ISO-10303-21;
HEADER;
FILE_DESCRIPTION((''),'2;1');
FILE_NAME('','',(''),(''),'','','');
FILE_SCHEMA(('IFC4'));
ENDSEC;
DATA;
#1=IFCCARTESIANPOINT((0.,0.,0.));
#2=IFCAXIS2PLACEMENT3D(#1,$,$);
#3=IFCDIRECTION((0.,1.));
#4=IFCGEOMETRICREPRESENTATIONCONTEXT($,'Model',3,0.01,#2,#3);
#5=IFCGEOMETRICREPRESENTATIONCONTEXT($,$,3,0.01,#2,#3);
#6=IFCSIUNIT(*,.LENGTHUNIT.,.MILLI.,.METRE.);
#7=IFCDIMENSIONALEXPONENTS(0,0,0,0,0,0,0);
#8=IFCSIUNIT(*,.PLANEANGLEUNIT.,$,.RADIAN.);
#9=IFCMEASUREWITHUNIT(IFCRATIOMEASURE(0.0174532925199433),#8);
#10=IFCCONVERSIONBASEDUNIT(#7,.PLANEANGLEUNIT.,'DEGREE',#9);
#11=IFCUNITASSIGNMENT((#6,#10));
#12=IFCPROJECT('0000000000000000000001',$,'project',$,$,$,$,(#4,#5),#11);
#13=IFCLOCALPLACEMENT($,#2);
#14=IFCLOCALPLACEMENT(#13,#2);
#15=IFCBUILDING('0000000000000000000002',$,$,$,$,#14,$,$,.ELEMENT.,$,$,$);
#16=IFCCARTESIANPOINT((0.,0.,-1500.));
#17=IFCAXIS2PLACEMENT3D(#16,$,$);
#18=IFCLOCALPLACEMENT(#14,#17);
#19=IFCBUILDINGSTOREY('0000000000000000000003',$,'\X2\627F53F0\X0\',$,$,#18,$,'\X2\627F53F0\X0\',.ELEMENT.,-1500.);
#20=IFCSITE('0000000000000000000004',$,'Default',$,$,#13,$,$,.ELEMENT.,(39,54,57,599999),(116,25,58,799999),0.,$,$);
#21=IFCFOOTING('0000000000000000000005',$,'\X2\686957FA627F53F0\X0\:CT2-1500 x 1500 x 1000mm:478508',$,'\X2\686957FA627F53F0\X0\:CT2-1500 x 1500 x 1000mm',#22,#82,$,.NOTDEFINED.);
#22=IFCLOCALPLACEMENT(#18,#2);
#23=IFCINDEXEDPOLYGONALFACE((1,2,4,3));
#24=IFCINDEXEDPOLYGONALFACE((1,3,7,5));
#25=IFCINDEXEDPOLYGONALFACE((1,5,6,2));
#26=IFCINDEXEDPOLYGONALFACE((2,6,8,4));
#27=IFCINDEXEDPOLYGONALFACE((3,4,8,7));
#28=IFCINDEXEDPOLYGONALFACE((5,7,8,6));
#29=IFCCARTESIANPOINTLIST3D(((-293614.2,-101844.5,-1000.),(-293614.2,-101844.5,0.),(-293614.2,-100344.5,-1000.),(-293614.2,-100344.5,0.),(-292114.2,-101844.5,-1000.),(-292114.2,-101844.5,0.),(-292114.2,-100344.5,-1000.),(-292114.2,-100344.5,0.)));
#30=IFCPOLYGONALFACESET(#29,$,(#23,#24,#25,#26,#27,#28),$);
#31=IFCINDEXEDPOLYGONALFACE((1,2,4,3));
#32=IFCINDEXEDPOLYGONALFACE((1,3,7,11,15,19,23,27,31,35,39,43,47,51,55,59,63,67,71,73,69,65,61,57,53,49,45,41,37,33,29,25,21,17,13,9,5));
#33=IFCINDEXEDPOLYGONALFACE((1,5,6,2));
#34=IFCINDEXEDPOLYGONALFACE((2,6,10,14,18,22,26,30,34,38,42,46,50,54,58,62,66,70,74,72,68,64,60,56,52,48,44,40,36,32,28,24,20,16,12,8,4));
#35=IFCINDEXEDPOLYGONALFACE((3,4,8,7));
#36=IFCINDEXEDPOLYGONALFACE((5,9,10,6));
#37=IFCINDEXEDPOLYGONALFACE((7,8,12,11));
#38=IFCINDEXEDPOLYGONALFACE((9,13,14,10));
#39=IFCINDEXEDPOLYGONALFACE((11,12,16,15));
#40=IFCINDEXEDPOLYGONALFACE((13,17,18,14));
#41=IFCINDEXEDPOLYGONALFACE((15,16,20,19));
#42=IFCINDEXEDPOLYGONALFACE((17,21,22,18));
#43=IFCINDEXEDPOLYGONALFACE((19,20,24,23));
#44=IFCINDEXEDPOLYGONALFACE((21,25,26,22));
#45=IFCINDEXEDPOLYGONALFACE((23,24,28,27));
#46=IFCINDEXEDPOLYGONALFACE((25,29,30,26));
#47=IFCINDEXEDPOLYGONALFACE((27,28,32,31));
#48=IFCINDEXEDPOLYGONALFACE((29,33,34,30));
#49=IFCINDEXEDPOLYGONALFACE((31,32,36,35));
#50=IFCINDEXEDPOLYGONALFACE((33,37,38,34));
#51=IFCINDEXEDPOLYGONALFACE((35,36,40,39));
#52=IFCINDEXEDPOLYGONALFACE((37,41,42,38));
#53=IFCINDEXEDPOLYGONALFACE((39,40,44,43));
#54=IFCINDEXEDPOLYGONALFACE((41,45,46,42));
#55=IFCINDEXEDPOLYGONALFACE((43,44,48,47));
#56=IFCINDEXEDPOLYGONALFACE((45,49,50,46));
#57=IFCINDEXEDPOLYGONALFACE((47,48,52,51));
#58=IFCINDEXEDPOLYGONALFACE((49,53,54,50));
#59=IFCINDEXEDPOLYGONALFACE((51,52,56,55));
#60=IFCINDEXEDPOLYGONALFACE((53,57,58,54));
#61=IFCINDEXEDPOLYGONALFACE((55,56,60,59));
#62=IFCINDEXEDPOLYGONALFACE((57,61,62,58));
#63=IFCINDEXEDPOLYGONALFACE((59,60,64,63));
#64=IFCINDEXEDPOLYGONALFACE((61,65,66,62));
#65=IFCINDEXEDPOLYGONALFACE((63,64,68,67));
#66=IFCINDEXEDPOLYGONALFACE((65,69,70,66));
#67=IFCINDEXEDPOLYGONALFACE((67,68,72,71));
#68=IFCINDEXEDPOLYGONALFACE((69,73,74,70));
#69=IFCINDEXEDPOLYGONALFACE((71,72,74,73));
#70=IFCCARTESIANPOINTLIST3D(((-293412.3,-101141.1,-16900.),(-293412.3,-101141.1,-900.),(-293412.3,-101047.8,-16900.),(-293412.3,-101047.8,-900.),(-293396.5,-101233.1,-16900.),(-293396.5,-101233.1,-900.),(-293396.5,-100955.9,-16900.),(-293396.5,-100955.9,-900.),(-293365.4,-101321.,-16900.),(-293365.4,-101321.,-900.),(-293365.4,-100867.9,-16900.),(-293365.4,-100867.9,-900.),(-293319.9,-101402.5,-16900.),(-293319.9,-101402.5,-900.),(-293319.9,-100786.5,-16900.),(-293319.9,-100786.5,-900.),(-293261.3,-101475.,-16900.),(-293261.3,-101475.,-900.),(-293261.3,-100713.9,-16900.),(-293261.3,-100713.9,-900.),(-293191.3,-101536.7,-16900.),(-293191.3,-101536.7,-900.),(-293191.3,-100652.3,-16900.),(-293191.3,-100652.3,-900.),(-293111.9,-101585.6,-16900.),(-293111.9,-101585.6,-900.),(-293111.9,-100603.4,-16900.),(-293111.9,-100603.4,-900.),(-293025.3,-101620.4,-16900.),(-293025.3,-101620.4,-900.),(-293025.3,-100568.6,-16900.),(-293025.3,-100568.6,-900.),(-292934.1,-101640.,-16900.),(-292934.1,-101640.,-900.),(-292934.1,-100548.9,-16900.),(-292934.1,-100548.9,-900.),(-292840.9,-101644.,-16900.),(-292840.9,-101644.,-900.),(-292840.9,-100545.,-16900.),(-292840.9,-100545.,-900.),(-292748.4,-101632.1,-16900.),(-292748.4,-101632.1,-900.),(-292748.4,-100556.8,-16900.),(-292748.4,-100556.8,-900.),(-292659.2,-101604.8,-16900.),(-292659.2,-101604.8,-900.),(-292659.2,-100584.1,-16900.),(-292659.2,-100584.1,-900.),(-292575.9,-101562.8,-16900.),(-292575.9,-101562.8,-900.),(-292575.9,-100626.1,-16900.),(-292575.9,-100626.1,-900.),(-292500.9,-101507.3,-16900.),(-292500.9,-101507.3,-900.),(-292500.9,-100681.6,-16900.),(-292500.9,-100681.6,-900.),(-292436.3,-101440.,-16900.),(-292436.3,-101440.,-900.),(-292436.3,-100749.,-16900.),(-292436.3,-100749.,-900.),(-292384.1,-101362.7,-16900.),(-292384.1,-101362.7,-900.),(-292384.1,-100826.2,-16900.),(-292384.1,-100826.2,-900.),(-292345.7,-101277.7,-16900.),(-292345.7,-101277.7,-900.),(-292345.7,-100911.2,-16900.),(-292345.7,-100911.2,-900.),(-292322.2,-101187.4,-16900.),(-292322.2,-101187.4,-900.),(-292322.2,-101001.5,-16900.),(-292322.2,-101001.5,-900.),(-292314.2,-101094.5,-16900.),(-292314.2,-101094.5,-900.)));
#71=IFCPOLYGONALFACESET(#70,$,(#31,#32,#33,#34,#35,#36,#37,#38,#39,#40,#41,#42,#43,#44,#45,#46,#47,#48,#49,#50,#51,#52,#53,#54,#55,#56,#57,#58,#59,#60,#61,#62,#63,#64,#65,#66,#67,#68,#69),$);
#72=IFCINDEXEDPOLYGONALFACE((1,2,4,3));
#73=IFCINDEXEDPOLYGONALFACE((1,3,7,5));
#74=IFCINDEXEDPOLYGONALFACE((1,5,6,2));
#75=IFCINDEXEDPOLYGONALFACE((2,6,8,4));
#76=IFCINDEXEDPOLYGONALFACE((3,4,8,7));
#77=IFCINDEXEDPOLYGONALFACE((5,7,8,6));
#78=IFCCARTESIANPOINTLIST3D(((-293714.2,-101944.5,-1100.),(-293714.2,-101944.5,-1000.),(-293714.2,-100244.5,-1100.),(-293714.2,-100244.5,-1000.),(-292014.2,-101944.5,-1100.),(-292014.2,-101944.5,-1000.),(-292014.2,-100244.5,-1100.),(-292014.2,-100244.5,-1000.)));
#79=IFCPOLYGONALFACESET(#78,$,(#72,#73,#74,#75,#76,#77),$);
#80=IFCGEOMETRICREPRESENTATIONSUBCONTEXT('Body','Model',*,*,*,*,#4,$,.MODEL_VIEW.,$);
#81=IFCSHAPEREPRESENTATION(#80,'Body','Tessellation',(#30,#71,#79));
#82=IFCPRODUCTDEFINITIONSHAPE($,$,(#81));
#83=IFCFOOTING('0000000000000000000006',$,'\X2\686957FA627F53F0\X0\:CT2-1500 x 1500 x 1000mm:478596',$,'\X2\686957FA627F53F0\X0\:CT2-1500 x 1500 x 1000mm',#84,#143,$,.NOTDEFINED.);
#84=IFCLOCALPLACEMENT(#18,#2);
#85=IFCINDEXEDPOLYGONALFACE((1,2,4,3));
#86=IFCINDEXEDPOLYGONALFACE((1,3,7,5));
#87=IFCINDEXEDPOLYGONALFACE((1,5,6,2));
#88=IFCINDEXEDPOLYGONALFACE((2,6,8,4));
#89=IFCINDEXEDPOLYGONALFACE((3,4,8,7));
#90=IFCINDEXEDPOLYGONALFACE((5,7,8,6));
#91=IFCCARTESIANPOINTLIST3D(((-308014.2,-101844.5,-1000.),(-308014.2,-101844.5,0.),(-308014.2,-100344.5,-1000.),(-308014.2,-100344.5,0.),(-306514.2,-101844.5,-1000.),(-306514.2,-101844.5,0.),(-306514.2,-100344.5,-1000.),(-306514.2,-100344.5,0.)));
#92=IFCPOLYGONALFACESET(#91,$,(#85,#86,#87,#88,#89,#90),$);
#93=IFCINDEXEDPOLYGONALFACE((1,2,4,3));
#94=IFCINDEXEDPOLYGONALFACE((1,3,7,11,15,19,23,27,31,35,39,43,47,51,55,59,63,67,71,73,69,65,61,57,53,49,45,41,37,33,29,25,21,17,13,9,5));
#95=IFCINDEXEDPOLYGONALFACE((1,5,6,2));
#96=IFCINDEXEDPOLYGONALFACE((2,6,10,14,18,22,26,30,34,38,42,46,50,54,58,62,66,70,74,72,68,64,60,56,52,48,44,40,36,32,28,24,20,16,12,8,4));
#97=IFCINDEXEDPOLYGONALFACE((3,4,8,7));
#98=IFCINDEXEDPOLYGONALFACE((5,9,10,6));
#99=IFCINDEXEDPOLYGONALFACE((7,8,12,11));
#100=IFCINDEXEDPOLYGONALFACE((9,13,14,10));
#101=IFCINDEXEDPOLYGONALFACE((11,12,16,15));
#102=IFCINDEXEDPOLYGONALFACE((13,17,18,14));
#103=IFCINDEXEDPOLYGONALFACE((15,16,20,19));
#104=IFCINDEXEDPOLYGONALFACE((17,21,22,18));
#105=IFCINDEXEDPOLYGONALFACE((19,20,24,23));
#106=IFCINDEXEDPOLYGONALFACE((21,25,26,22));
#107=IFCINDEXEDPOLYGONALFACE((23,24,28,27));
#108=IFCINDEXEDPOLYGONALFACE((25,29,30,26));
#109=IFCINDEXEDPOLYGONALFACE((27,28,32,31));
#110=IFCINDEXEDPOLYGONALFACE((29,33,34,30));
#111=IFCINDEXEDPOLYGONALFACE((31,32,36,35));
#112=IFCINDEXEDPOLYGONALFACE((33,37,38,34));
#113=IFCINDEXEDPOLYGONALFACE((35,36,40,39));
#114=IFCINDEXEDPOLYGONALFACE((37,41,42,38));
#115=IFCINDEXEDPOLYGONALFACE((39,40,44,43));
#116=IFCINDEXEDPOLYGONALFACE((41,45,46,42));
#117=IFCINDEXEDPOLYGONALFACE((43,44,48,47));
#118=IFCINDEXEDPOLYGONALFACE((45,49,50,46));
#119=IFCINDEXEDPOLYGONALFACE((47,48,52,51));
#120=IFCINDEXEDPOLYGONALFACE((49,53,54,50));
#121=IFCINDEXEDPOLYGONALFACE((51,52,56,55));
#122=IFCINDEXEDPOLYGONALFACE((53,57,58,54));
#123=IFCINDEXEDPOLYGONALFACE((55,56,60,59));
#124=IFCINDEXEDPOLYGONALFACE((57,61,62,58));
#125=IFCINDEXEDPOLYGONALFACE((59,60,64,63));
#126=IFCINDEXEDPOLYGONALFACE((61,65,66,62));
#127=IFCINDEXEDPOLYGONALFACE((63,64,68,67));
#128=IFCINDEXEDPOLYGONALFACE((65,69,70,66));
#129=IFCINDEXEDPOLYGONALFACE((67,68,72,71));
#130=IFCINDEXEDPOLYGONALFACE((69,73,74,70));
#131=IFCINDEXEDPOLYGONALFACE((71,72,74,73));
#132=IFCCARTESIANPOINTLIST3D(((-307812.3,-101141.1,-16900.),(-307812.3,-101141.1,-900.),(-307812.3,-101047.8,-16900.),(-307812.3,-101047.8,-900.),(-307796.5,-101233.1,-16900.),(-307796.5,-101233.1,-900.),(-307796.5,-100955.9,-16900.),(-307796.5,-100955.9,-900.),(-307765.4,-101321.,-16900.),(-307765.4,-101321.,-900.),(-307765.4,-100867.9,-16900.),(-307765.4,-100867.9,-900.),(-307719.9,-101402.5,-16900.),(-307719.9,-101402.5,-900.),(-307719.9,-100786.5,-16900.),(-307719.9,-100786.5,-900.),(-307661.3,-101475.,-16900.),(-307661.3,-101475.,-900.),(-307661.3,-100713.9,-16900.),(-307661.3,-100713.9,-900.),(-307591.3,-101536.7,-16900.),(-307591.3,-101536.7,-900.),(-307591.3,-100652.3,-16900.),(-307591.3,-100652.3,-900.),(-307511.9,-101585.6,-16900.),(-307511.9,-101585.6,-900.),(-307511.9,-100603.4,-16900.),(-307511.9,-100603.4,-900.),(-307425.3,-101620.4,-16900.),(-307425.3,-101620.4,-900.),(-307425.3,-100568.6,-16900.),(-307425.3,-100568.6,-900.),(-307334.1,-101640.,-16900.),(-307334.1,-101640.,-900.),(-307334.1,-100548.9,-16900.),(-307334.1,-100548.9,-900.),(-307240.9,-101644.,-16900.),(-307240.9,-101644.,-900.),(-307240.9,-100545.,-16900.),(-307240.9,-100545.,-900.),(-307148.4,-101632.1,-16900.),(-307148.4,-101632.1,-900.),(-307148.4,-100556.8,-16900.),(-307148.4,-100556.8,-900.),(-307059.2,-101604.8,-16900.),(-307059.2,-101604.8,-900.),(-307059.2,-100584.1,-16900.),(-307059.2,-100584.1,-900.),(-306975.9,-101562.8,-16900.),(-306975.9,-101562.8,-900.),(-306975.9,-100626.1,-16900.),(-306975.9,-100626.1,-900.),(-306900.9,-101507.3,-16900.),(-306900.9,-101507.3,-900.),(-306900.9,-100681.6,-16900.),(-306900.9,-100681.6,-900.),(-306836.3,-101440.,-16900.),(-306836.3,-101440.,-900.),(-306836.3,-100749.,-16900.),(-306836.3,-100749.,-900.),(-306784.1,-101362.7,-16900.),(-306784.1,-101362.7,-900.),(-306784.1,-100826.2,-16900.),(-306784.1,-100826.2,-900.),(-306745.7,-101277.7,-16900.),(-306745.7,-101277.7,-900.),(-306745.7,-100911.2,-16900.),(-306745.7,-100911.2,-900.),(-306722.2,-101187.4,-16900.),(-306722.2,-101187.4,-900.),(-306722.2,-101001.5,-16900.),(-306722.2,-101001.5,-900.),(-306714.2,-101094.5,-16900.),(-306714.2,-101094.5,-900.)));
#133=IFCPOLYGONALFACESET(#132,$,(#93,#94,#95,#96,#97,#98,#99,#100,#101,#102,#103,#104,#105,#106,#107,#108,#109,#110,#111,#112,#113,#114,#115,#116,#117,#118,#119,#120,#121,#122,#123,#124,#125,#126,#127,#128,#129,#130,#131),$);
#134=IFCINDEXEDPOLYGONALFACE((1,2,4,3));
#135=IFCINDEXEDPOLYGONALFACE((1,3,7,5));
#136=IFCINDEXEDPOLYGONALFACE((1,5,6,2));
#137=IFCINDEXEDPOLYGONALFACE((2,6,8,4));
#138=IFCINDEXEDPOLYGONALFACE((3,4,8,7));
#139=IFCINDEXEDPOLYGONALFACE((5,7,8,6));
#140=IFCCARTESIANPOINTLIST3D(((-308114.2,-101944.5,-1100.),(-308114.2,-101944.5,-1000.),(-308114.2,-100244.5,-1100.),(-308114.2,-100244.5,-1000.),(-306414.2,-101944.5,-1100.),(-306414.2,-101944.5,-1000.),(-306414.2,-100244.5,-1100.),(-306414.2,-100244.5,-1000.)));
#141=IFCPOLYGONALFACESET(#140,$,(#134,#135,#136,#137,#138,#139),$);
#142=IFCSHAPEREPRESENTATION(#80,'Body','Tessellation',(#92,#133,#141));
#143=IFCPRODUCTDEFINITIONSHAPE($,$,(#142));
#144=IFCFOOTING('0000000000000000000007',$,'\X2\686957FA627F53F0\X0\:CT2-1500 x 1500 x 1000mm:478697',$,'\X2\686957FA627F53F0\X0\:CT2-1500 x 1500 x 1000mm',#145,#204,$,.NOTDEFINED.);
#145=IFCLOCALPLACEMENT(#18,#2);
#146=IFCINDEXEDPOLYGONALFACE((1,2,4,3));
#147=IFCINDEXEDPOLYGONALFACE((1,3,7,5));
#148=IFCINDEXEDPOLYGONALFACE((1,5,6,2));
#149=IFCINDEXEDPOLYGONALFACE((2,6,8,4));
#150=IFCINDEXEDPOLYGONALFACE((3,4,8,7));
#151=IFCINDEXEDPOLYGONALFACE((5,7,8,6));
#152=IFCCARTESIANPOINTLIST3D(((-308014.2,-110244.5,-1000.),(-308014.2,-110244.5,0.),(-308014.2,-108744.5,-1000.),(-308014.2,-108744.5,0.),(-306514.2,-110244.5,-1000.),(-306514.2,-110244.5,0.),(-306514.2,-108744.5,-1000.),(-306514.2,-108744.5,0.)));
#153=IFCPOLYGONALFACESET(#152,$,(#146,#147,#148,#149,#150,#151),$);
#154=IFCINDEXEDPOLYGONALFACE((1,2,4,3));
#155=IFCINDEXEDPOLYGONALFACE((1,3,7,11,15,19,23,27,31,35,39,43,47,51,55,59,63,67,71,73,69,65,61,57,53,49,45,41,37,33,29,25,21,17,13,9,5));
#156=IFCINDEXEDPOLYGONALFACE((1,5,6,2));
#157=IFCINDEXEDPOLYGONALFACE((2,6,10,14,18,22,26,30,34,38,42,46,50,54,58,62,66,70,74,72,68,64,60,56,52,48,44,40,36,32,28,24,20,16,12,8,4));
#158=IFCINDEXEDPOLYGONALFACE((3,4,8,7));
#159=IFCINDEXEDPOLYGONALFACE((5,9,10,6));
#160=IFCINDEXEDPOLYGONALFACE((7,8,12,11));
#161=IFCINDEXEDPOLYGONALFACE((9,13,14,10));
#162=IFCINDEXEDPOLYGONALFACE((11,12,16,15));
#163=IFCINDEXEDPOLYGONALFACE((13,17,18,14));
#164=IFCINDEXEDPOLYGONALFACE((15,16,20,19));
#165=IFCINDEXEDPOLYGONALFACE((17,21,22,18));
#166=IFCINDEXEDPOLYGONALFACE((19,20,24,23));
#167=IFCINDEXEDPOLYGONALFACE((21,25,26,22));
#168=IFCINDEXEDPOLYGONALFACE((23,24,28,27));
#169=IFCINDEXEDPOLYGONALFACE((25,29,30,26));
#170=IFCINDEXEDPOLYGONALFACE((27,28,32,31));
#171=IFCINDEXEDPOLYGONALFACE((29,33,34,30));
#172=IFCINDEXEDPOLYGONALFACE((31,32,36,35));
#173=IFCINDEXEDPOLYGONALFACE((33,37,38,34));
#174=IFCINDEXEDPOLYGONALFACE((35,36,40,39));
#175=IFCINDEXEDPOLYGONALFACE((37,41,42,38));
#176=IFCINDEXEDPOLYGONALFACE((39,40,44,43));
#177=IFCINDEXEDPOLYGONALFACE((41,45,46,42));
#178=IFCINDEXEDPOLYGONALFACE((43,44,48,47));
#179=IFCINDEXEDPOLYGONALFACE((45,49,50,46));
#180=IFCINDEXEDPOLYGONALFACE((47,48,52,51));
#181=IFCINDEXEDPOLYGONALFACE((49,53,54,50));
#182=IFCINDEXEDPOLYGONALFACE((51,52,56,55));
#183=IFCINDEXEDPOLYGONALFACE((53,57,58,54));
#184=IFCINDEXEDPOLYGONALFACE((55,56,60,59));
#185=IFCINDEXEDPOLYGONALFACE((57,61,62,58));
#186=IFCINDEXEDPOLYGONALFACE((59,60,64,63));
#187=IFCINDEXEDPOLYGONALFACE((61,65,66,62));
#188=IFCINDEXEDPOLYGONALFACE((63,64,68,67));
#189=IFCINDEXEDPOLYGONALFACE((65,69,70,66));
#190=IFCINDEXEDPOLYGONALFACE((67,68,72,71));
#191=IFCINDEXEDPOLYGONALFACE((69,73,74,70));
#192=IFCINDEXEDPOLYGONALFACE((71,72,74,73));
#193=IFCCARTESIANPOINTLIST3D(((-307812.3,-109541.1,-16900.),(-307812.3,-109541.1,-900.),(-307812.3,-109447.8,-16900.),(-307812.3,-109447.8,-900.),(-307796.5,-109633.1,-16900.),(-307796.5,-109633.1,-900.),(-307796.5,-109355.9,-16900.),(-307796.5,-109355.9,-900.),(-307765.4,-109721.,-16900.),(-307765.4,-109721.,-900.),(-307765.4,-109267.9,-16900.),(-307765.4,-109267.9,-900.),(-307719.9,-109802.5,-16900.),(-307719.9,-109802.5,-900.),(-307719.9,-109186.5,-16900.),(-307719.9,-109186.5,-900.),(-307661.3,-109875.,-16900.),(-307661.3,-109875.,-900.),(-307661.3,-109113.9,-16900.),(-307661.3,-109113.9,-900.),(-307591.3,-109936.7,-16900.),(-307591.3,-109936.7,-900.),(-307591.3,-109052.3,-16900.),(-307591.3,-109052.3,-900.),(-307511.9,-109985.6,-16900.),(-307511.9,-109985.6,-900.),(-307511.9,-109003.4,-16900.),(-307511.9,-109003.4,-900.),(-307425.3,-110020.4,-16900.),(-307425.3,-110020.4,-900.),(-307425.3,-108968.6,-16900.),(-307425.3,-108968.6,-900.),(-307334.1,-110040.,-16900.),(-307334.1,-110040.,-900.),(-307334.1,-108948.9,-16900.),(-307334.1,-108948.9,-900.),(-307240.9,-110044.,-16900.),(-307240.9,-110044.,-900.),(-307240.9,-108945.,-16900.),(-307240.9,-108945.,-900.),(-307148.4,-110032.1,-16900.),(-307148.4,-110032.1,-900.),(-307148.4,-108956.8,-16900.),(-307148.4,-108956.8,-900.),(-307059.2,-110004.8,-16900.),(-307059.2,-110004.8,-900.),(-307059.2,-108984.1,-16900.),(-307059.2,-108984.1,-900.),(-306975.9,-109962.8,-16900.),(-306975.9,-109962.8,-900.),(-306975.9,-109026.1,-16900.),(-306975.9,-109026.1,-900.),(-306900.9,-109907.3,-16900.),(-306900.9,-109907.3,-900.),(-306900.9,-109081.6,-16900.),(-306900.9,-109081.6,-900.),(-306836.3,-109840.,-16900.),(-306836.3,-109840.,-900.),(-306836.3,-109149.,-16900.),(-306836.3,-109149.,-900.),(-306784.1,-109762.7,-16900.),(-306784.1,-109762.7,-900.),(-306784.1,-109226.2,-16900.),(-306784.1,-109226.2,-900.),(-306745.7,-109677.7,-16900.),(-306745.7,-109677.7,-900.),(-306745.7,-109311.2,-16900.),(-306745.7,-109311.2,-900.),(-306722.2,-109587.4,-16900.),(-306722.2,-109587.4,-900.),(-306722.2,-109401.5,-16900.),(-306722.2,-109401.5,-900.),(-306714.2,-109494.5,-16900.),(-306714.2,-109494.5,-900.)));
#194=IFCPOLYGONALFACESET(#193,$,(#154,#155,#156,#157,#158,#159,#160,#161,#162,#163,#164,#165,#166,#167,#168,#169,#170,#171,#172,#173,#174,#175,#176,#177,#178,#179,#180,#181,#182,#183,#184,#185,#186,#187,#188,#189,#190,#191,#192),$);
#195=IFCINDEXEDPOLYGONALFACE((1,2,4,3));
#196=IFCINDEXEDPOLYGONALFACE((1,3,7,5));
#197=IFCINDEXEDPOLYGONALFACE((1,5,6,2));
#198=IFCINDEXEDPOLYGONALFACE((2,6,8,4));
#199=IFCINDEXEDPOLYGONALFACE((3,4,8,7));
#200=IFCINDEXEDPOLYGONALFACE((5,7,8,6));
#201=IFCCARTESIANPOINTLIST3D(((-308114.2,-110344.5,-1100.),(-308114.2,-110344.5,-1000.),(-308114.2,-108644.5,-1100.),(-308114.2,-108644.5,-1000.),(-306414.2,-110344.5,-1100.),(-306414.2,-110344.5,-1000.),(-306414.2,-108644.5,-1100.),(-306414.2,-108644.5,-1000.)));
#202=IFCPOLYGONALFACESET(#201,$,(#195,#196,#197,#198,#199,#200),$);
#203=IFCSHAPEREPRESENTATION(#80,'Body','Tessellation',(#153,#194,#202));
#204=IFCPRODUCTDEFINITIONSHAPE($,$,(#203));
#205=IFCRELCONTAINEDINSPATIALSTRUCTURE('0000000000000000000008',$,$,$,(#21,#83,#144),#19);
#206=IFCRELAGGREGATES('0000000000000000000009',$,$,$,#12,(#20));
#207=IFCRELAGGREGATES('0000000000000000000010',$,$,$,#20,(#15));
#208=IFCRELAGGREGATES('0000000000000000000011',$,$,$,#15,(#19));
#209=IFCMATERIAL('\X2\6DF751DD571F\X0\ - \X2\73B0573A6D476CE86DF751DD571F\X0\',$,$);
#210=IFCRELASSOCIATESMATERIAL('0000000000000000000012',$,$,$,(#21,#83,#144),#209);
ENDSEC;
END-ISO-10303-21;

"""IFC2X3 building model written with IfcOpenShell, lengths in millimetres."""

from ifc_helpers import new_model, entity, si_unit, converted_unit, direction, frame, frame_2d, origin, origin_2d_with_axis, place, context, subcontext, project, spatial, rectangle, circle, extrude, material, element, save


model = new_model("IFC2X3")

# Units and contexts
model_context = context("Model", 3, precision=0.01, world=origin(), true_north=direction((0.0, 1.0)))
context_of_model = context(None, 3, precision=0.01, world=origin(), true_north=direction((0.0, 1.0)))
body_context = subcontext(model_context, "Body", "Model", "MODEL_VIEW")
ifc_project = project(units=[si_unit("LENGTHUNIT", "METRE", prefix="MILLI"), converted_unit("PLANEANGLEUNIT", "DEGREE", entity("IfcRatioMeasure", 0.0174532925199433), si_unit("PLANEANGLEUNIT", "RADIAN"), dimensions=[0, 0, 0, 0, 0, 0, 0])], contexts=[model_context, context_of_model])

# Site, building, storey
site_placement = place(None, origin())
site = spatial("IfcSite", under=ifc_project, at=site_placement, Name="Default", CompositionType="ELEMENT", RefLatitude=(39, 54, 57, 599999), RefLongitude=(116, 25, 58, 799999), RefElevation=0.0)
building_placement = place(site_placement, origin())
building = spatial("IfcBuilding", under=site, at=building_placement, CompositionType="ELEMENT")
storey_placement = place(building_placement, frame((0.0, 0.0, -1500.0)))
storey = spatial("IfcBuildingStorey", under=building, at=storey_placement, Name="承台", LongName="承台", CompositionType="ELEMENT", Elevation=-1500.0)

# Footings
ifc_material_1 = material(Name="混凝土 - 现场浇注混凝土")
footing_1_placement = place(storey_placement, frame((-293714.2, -101944.5, -16900.0)))
element("IfcFooting", 1, at=footing_1_placement, inside=storey, material=ifc_material_1, Name="桩基承台:CT2-1500 x 1500 x 1000mm:478508", ObjectType="桩基承台:CT2-1500 x 1500 x 1000mm", PredefinedType="NOTDEFINED", context=body_context, shape_type="SweptSolid", body=[
    extrude(rectangle(XDim=1500.0, YDim=1500.0, at=origin_2d_with_axis()), frame((850.0, 850.0, 15900.0), z_axis=(0.0, 0.0, 1.0), x_axis=(-1.0, 0.0, 0.0)), (0.0, 0.0, 1.0), 1000.0),
    extrude(circle(Radius=550.0, at=origin_2d_with_axis()), frame((850.0, 850.0, 0.0)), (0.0, 0.0, 1.0), 16000.0),
    extrude(rectangle(XDim=1700.0, YDim=1700.0, at=frame_2d((0.0, 0.0), x_axis=(1.0, 0.0))), frame((850.0, 850.0, 15800.0), z_axis=(0.0, 0.0, 1.0), x_axis=(0.0, 1.0, 0.0)), (0.0, 0.0, 1.0), 100.0),
])
for number, where, name in (
    (2, (-308114.2, -101944.5, -16900.0), "桩基承台:CT2-1500 x 1500 x 1000mm:478596"),
    (3, (-308114.2, -110344.5, -16900.0), "桩基承台:CT2-1500 x 1500 x 1000mm:478697"),
):
    element("IfcFooting", number, at=place(storey_placement, frame(where)), inside=storey, material=ifc_material_1, Name=name, ObjectType="桩基承台:CT2-1500 x 1500 x 1000mm", PredefinedType="NOTDEFINED", context=body_context, shape_type="SweptSolid", body=[
        extrude(rectangle(XDim=1500.0, YDim=1500.0, at=origin_2d_with_axis()), frame((850.0, 850.0, 15900.0), z_axis=(0.0, 0.0, 1.0), x_axis=(-1.0, 0.0, 0.0)), (0.0, 0.0, 1.0), 1000.0),
        extrude(circle(Radius=550.0, at=origin_2d_with_axis()), frame((850.0, 850.0, 0.0)), (0.0, 0.0, 1.0), 16000.0),
        extrude(rectangle(XDim=1700.0, YDim=1700.0, at=frame_2d((0.0, 0.0), x_axis=(1.0, 0.0))), frame((850.0, 850.0, 15800.0), z_axis=(0.0, 0.0, 1.0), x_axis=(0.0, 1.0, 0.0)), (0.0, 0.0, 1.0), 100.0),
    ])

save(model, "model.ifc")
